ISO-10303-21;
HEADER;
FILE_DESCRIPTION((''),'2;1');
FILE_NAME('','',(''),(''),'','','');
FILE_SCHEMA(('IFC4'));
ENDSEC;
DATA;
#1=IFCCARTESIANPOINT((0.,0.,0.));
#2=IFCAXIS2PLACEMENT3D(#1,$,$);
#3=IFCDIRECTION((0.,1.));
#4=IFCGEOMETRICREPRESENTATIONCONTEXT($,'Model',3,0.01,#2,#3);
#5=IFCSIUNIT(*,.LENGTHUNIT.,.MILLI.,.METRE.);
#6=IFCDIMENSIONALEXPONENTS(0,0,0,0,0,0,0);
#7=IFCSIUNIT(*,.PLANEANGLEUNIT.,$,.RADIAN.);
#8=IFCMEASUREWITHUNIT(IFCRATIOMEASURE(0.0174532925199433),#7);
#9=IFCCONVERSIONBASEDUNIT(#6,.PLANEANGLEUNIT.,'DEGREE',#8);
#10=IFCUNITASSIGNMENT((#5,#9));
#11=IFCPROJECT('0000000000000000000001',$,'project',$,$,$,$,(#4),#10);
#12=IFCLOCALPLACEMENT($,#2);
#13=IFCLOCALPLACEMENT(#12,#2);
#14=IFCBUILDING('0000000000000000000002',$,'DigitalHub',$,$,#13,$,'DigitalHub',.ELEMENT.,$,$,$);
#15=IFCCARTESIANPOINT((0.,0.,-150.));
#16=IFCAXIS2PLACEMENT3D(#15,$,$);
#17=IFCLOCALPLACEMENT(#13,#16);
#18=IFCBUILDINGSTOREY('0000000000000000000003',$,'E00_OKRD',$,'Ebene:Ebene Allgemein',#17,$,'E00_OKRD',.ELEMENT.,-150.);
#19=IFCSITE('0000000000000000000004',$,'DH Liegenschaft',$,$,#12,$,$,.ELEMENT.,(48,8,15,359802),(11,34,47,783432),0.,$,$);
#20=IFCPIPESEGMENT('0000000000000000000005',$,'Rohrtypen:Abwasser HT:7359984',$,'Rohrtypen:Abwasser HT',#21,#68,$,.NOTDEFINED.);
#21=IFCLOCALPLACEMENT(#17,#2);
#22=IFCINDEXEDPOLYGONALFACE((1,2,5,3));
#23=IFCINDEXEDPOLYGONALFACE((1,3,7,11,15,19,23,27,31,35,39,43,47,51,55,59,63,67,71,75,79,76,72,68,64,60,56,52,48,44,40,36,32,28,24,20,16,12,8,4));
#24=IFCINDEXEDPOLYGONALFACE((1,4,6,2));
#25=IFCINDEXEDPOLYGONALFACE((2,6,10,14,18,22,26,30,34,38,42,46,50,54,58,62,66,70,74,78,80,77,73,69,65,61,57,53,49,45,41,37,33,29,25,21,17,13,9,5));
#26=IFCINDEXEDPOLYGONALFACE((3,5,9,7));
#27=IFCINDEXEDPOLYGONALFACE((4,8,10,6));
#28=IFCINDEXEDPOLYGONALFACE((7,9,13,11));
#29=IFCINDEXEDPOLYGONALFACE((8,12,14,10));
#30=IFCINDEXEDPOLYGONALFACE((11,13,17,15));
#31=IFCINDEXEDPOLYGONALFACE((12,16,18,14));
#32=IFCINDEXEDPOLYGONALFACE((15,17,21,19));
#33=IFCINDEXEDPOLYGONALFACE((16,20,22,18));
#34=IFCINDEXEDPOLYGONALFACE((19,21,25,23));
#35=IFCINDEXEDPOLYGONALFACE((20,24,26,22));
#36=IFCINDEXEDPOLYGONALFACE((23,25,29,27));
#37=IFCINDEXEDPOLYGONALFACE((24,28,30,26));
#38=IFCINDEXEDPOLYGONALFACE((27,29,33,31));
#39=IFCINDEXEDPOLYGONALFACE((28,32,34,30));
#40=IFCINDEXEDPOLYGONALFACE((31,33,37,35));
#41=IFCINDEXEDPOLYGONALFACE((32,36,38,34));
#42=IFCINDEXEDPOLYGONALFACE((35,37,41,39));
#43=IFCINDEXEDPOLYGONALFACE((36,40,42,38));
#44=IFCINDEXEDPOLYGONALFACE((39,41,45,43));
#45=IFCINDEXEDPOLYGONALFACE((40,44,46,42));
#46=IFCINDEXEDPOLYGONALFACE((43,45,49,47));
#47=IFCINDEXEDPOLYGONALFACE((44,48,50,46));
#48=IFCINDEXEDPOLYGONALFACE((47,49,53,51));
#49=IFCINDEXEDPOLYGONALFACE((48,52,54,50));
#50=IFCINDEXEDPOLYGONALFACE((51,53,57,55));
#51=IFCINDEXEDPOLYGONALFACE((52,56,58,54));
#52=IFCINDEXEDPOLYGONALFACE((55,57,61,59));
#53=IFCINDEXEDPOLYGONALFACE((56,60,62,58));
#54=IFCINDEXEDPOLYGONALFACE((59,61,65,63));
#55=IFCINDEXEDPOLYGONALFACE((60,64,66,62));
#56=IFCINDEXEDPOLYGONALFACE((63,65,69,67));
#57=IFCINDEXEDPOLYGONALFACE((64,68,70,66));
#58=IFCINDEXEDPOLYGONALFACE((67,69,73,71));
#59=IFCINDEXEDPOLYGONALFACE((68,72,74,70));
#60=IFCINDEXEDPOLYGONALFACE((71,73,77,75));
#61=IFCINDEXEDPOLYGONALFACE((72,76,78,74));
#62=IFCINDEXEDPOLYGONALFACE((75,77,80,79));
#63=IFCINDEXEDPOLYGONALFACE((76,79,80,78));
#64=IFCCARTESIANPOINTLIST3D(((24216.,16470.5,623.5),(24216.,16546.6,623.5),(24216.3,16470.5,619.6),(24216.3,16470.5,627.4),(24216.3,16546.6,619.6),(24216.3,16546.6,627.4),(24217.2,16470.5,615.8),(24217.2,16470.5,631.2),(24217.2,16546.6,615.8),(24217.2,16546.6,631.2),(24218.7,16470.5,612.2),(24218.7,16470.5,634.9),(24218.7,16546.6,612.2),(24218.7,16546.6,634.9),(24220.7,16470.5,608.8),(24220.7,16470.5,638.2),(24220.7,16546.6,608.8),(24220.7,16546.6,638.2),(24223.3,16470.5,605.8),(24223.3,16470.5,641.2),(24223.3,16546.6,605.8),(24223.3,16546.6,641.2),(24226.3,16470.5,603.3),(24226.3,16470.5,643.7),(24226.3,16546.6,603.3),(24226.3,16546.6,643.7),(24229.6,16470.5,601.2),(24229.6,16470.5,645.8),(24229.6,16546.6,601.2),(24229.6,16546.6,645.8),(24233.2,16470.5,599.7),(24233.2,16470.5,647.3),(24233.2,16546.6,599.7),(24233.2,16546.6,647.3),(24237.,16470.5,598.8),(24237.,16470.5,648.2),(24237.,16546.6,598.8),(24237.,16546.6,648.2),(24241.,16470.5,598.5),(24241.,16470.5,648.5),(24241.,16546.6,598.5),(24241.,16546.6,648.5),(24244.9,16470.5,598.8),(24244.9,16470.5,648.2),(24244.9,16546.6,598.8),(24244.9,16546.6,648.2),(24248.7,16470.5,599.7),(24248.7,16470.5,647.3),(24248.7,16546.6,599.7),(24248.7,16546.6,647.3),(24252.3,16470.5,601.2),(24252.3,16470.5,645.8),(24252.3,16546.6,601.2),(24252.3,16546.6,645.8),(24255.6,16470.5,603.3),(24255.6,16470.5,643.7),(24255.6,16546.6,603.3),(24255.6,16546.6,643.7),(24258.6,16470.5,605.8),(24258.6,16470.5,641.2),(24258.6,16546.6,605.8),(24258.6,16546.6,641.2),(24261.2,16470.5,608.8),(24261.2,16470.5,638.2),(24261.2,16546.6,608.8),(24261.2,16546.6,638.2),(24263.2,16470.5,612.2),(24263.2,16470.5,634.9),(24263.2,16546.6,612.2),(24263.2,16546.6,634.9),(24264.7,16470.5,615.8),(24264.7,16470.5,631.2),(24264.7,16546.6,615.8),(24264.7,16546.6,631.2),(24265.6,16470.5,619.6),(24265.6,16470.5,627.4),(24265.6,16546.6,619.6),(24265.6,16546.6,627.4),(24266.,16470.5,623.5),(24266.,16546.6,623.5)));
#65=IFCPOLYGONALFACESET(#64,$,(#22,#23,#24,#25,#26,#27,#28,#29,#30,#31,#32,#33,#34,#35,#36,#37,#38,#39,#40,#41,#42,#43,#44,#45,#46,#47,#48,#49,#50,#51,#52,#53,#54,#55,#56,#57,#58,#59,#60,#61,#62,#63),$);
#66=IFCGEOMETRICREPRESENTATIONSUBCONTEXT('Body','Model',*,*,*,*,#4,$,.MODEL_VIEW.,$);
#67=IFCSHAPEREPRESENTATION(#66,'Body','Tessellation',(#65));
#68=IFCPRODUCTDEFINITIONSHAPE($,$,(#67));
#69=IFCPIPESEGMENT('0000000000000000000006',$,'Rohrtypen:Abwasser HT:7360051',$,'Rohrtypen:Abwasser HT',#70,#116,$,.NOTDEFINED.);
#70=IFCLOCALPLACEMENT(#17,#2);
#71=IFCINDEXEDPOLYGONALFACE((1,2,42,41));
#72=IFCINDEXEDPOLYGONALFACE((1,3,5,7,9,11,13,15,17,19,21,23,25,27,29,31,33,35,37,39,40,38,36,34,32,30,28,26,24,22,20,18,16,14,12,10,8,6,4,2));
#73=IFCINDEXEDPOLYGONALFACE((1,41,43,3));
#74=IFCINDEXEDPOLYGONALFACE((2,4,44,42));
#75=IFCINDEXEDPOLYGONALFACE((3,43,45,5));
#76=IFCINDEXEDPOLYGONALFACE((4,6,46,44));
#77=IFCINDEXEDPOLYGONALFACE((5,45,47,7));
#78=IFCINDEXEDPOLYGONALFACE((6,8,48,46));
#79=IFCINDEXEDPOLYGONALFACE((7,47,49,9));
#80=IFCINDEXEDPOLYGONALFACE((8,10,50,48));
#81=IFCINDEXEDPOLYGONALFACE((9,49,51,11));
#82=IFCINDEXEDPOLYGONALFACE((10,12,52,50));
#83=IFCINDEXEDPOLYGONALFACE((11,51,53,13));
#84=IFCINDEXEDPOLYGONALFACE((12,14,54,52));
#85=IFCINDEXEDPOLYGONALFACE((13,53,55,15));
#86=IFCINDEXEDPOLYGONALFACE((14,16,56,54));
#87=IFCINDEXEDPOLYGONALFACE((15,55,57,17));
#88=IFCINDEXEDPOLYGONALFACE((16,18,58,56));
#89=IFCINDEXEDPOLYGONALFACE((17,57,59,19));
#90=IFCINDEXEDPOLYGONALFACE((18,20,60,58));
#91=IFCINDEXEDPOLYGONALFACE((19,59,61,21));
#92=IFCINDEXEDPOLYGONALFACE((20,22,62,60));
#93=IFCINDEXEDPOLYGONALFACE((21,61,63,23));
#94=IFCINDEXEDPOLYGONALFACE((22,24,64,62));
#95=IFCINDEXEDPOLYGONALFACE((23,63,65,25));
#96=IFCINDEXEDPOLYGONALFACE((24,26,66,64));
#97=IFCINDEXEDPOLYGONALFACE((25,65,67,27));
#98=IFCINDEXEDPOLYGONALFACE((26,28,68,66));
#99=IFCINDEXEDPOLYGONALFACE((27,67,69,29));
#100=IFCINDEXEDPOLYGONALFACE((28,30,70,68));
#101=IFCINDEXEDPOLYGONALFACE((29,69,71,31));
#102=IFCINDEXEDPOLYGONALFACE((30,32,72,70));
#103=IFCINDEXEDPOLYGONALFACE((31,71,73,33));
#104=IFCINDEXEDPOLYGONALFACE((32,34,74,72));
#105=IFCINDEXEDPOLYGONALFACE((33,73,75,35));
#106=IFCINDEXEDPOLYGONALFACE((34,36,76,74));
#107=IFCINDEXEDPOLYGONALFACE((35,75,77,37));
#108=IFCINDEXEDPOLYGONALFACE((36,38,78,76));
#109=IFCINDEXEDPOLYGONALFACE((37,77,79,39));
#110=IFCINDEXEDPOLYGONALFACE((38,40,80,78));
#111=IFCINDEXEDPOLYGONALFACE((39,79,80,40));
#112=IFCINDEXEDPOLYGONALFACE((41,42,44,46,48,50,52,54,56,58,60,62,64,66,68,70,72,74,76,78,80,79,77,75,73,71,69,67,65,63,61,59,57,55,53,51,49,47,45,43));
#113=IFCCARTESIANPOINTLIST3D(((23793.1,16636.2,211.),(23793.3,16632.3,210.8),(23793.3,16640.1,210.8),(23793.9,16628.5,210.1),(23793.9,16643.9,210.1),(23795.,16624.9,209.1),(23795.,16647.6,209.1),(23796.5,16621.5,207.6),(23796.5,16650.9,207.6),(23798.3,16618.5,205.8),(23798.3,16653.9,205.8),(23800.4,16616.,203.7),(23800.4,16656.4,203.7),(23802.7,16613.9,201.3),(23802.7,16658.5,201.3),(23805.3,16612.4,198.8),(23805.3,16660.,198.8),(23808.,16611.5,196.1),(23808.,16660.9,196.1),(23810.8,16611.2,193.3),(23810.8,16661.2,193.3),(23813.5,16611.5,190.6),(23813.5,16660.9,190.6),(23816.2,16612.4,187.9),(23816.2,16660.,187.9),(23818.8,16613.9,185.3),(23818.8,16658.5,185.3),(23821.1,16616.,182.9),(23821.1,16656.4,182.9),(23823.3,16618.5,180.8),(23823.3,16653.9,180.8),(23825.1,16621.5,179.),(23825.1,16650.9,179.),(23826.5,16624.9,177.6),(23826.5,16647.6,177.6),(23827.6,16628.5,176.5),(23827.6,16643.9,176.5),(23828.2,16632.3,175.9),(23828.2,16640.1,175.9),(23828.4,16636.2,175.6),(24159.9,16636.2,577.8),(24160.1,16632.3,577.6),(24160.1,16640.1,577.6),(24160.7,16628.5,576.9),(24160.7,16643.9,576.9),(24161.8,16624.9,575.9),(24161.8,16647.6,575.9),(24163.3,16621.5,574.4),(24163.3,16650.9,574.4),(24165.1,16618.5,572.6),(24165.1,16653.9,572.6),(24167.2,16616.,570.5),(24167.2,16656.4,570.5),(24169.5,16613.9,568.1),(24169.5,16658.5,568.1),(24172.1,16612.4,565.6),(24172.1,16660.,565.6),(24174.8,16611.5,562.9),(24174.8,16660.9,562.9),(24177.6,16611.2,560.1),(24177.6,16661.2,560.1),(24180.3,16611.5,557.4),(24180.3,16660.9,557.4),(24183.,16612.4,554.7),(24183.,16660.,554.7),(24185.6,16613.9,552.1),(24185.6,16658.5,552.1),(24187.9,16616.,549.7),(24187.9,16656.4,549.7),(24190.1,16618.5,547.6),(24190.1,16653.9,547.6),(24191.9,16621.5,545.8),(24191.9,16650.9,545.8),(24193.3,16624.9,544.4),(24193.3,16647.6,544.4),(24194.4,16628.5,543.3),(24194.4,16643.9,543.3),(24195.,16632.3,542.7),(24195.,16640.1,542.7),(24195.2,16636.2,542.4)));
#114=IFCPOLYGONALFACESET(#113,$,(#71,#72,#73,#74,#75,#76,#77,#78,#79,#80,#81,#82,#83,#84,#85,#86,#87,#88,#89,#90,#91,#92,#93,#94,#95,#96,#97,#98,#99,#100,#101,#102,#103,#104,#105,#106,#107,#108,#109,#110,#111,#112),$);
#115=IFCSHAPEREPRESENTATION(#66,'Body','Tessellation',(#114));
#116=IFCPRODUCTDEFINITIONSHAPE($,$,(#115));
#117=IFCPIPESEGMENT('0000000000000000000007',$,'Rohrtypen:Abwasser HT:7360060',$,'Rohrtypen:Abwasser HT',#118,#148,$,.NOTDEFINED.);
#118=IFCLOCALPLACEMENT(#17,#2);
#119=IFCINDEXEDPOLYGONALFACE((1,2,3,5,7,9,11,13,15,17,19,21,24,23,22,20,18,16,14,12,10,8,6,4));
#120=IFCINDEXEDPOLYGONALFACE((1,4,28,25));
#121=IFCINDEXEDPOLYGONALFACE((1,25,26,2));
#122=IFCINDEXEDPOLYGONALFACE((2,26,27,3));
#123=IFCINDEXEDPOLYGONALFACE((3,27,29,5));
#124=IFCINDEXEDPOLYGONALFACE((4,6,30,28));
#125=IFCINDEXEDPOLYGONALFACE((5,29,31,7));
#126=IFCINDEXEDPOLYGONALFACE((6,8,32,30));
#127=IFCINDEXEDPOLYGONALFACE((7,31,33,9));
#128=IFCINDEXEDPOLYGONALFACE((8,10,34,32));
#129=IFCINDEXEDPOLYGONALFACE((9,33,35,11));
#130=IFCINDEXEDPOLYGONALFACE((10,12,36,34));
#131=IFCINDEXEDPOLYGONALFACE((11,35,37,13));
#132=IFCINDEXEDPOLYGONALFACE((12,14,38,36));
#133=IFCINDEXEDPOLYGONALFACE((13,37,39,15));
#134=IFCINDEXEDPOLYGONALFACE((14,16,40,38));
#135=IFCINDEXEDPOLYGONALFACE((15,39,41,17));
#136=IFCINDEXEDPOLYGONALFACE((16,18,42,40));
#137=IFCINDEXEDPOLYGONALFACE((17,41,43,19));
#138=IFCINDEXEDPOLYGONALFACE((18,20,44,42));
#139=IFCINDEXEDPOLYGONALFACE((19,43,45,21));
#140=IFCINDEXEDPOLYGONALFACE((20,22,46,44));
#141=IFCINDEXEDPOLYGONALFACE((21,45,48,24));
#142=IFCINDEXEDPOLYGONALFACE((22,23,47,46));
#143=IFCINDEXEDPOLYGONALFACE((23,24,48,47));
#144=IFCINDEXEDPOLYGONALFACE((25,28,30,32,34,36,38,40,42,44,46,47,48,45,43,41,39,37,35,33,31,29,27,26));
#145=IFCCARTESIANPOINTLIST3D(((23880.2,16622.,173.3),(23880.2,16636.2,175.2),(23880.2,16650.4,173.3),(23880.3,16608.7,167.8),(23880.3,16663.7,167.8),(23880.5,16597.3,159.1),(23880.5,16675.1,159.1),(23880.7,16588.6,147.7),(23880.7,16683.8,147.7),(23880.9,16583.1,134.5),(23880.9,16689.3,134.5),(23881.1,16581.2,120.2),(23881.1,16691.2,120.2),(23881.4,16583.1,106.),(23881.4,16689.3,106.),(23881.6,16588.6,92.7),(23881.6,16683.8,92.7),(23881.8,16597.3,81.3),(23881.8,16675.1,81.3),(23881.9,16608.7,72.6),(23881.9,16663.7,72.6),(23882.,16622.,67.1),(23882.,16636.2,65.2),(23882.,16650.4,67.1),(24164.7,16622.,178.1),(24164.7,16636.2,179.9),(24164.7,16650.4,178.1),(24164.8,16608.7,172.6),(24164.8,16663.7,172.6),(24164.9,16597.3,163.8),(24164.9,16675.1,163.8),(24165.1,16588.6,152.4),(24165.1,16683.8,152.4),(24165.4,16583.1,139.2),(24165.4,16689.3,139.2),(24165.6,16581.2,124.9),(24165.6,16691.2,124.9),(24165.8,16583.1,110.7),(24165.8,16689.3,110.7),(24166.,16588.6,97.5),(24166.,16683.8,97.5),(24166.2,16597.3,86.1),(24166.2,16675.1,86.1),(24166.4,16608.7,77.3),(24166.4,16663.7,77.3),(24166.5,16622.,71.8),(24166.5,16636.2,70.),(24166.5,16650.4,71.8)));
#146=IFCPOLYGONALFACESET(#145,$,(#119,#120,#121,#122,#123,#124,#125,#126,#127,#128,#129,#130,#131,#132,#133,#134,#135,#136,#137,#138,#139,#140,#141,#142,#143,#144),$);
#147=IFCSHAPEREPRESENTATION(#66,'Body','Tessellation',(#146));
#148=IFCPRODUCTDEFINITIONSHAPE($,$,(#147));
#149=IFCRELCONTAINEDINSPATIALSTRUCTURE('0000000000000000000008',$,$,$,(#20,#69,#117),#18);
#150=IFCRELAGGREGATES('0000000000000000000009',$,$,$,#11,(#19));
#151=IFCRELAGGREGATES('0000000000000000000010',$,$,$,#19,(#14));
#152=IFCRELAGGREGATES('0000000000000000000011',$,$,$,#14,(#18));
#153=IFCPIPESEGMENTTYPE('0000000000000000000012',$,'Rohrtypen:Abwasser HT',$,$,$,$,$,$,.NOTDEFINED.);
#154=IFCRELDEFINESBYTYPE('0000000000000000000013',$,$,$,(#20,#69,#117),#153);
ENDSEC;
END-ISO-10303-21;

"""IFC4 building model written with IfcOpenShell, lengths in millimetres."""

from ifc_helpers import new_model, entity, si_unit, converted_unit, direction, frame, origin, place, context, subcontext, project, spatial, indexed_curve, outline, extrude, type_object, element, save


model = new_model("IFC4")

# Units and contexts
model_context = context("Model", 3, precision=0.01, world=origin(), true_north=direction((0.0, 1.0)))
body_context = subcontext(model_context, "Body", "Model", "MODEL_VIEW")
ifc_project = project(units=[si_unit("LENGTHUNIT", "METRE", prefix="MILLI"), converted_unit("PLANEANGLEUNIT", "DEGREE", entity("IfcRatioMeasure", 0.0174532925199433), si_unit("PLANEANGLEUNIT", "RADIAN"), dimensions=[0, 0, 0, 0, 0, 0, 0])], contexts=[model_context])

# Site, building, storey
site_placement = place(None, origin())
site = spatial("IfcSite", under=ifc_project, at=site_placement, Name="DH Liegenschaft", CompositionType="ELEMENT", RefLatitude=(48, 8, 15, 359802), RefLongitude=(11, 34, 47, 783432), RefElevation=0.0)
building_placement = place(site_placement, origin())
building = spatial("IfcBuilding", under=site, at=building_placement, Name="DigitalHub", LongName="DigitalHub", CompositionType="ELEMENT")
storey_placement = place(building_placement, frame((0.0, 0.0, -150.0)))
storey = spatial("IfcBuildingStorey", under=building, at=storey_placement, Name="E00_OKRD", ObjectType="Ebene:Ebene Allgemein", LongName="E00_OKRD", CompositionType="ELEMENT", Elevation=-150.0)

# Pipe segments
pipe_segment_type_1 = type_object("IfcPipeSegmentType", Name="Rohrtypen:Abwasser HT", PredefinedType="NOTDEFINED")
pipe_segment_1_placement = place(storey_placement, frame((24214.4, 16470.5, 596.9)))
element("IfcPipeSegment", 1, at=pipe_segment_1_placement, inside=storey, type_object=pipe_segment_type_1, Name="Rohrtypen:Abwasser HT:7359984", ObjectType="Rohrtypen:Abwasser HT", PredefinedType="NOTDEFINED", context=body_context, shape_type="SweptSolid", body=[
    extrude(outline(indexed_curve([(25.0, 0.0), (24.7, 3.9), (23.8, 7.7), (22.3, 11.3), (20.2, 14.7), (17.7, 17.7), (14.7, 20.2), (11.3, 22.3), (7.7, 23.8), (3.9, 24.7), (0.0, 25.0), (-3.9, 24.7), (-7.7, 23.8), (-11.3, 22.3), (-14.7, 20.2), (-17.7, 17.7), (-20.2, 14.7), (-22.3, 11.3), (-23.8, 7.7), (-24.7, 3.9), (-25.0, 0.0), (-24.7, -3.9), (-23.8, -7.7), (-22.3, -11.3), (-20.2, -14.7), (-17.7, -17.7), (-14.7, -20.2), (-11.3, -22.3), (-7.7, -23.8), (-3.9, -24.7), (0.0, -25.0), (3.9, -24.7), (7.7, -23.8), (11.3, -22.3), (14.7, -20.2), (17.7, -17.7), (20.2, -14.7), (22.3, -11.3), (23.8, -7.7), (24.7, -3.9), (25.0, 0.0)], self_intersect=False)), frame((26.6, 0.0, 26.6), z_axis=(0.0, 1.0, 0.0), x_axis=(1.0, 0.0, 0.0)), (0.0, 0.0, 1.0), 76.0),
])
pipe_segment_2_placement = place(storey_placement, frame((23791.5, 16609.6, 174.0)))
element("IfcPipeSegment", 2, at=pipe_segment_2_placement, inside=storey, type_object=pipe_segment_type_1, Name="Rohrtypen:Abwasser HT:7360051", ObjectType="Rohrtypen:Abwasser HT", PredefinedType="NOTDEFINED", context=body_context, shape_type="SweptSolid", body=[
    extrude(outline(indexed_curve([(25.0, 0.0), (24.7, 3.9), (23.8, 7.7), (22.3, 11.3), (20.2, 14.7), (17.7, 17.7), (14.7, 20.2), (11.3, 22.3), (7.7, 23.8), (3.9, 24.7), (0.0, 25.0), (-3.9, 24.7), (-7.7, 23.8), (-11.3, 22.3), (-14.7, 20.2), (-17.7, 17.7), (-20.2, 14.7), (-22.3, 11.3), (-23.8, 7.7), (-24.7, 3.9), (-25.0, 0.0), (-24.7, -3.9), (-23.8, -7.7), (-22.3, -11.3), (-20.2, -14.7), (-17.7, -17.7), (-14.7, -20.2), (-11.3, -22.3), (-7.7, -23.8), (-3.9, -24.7), (0.0, -25.0), (3.9, -24.7), (7.7, -23.8), (11.3, -22.3), (14.7, -20.2), (17.7, -17.7), (20.2, -14.7), (22.3, -11.3), (23.8, -7.7), (24.7, -3.9), (25.0, 0.0)], self_intersect=False)), frame((19.3, 26.6, 19.3), z_axis=(0.707107, 0.0, 0.707107), x_axis=(0.0, -1.0, 0.0)), (0.0, 0.0, 1.0), 518.7),
])
pipe_segment_3_placement = place(storey_placement, frame((23878.6, 16579.6, 63.6)))
element("IfcPipeSegment", 3, at=pipe_segment_3_placement, inside=storey, type_object=pipe_segment_type_1, Name="Rohrtypen:Abwasser HT:7360060", ObjectType="Rohrtypen:Abwasser HT", PredefinedType="NOTDEFINED", context=body_context, shape_type="SweptSolid", body=[
    extrude(outline(indexed_curve([(-7.2, -54.5), (7.2, -54.5), (21.0, -50.8), (33.5, -43.6), (43.6, -33.5), (50.8, -21.0), (54.5, -7.2), (54.5, 7.2), (50.8, 21.0), (43.6, 33.5), (33.5, 43.6), (21.0, 50.8), (7.2, 54.5), (-7.2, 54.5), (-21.0, 50.8), (-33.5, 43.6), (-43.6, 33.5), (-50.8, 21.0), (-54.5, 7.2), (-54.5, -7.2), (-50.8, -21.0), (-43.6, -33.5), (-33.5, -43.6), (-21.0, -50.8), (-7.2, -54.5)], self_intersect=False)), frame((2.5, 56.6, 56.6), z_axis=(0.999862, 0.0, 0.016604), x_axis=(-0.016462, -0.130526, 0.991308)), (0.0, 0.0, 1.0), 284.5),
])

save(model, "model.ifc")
